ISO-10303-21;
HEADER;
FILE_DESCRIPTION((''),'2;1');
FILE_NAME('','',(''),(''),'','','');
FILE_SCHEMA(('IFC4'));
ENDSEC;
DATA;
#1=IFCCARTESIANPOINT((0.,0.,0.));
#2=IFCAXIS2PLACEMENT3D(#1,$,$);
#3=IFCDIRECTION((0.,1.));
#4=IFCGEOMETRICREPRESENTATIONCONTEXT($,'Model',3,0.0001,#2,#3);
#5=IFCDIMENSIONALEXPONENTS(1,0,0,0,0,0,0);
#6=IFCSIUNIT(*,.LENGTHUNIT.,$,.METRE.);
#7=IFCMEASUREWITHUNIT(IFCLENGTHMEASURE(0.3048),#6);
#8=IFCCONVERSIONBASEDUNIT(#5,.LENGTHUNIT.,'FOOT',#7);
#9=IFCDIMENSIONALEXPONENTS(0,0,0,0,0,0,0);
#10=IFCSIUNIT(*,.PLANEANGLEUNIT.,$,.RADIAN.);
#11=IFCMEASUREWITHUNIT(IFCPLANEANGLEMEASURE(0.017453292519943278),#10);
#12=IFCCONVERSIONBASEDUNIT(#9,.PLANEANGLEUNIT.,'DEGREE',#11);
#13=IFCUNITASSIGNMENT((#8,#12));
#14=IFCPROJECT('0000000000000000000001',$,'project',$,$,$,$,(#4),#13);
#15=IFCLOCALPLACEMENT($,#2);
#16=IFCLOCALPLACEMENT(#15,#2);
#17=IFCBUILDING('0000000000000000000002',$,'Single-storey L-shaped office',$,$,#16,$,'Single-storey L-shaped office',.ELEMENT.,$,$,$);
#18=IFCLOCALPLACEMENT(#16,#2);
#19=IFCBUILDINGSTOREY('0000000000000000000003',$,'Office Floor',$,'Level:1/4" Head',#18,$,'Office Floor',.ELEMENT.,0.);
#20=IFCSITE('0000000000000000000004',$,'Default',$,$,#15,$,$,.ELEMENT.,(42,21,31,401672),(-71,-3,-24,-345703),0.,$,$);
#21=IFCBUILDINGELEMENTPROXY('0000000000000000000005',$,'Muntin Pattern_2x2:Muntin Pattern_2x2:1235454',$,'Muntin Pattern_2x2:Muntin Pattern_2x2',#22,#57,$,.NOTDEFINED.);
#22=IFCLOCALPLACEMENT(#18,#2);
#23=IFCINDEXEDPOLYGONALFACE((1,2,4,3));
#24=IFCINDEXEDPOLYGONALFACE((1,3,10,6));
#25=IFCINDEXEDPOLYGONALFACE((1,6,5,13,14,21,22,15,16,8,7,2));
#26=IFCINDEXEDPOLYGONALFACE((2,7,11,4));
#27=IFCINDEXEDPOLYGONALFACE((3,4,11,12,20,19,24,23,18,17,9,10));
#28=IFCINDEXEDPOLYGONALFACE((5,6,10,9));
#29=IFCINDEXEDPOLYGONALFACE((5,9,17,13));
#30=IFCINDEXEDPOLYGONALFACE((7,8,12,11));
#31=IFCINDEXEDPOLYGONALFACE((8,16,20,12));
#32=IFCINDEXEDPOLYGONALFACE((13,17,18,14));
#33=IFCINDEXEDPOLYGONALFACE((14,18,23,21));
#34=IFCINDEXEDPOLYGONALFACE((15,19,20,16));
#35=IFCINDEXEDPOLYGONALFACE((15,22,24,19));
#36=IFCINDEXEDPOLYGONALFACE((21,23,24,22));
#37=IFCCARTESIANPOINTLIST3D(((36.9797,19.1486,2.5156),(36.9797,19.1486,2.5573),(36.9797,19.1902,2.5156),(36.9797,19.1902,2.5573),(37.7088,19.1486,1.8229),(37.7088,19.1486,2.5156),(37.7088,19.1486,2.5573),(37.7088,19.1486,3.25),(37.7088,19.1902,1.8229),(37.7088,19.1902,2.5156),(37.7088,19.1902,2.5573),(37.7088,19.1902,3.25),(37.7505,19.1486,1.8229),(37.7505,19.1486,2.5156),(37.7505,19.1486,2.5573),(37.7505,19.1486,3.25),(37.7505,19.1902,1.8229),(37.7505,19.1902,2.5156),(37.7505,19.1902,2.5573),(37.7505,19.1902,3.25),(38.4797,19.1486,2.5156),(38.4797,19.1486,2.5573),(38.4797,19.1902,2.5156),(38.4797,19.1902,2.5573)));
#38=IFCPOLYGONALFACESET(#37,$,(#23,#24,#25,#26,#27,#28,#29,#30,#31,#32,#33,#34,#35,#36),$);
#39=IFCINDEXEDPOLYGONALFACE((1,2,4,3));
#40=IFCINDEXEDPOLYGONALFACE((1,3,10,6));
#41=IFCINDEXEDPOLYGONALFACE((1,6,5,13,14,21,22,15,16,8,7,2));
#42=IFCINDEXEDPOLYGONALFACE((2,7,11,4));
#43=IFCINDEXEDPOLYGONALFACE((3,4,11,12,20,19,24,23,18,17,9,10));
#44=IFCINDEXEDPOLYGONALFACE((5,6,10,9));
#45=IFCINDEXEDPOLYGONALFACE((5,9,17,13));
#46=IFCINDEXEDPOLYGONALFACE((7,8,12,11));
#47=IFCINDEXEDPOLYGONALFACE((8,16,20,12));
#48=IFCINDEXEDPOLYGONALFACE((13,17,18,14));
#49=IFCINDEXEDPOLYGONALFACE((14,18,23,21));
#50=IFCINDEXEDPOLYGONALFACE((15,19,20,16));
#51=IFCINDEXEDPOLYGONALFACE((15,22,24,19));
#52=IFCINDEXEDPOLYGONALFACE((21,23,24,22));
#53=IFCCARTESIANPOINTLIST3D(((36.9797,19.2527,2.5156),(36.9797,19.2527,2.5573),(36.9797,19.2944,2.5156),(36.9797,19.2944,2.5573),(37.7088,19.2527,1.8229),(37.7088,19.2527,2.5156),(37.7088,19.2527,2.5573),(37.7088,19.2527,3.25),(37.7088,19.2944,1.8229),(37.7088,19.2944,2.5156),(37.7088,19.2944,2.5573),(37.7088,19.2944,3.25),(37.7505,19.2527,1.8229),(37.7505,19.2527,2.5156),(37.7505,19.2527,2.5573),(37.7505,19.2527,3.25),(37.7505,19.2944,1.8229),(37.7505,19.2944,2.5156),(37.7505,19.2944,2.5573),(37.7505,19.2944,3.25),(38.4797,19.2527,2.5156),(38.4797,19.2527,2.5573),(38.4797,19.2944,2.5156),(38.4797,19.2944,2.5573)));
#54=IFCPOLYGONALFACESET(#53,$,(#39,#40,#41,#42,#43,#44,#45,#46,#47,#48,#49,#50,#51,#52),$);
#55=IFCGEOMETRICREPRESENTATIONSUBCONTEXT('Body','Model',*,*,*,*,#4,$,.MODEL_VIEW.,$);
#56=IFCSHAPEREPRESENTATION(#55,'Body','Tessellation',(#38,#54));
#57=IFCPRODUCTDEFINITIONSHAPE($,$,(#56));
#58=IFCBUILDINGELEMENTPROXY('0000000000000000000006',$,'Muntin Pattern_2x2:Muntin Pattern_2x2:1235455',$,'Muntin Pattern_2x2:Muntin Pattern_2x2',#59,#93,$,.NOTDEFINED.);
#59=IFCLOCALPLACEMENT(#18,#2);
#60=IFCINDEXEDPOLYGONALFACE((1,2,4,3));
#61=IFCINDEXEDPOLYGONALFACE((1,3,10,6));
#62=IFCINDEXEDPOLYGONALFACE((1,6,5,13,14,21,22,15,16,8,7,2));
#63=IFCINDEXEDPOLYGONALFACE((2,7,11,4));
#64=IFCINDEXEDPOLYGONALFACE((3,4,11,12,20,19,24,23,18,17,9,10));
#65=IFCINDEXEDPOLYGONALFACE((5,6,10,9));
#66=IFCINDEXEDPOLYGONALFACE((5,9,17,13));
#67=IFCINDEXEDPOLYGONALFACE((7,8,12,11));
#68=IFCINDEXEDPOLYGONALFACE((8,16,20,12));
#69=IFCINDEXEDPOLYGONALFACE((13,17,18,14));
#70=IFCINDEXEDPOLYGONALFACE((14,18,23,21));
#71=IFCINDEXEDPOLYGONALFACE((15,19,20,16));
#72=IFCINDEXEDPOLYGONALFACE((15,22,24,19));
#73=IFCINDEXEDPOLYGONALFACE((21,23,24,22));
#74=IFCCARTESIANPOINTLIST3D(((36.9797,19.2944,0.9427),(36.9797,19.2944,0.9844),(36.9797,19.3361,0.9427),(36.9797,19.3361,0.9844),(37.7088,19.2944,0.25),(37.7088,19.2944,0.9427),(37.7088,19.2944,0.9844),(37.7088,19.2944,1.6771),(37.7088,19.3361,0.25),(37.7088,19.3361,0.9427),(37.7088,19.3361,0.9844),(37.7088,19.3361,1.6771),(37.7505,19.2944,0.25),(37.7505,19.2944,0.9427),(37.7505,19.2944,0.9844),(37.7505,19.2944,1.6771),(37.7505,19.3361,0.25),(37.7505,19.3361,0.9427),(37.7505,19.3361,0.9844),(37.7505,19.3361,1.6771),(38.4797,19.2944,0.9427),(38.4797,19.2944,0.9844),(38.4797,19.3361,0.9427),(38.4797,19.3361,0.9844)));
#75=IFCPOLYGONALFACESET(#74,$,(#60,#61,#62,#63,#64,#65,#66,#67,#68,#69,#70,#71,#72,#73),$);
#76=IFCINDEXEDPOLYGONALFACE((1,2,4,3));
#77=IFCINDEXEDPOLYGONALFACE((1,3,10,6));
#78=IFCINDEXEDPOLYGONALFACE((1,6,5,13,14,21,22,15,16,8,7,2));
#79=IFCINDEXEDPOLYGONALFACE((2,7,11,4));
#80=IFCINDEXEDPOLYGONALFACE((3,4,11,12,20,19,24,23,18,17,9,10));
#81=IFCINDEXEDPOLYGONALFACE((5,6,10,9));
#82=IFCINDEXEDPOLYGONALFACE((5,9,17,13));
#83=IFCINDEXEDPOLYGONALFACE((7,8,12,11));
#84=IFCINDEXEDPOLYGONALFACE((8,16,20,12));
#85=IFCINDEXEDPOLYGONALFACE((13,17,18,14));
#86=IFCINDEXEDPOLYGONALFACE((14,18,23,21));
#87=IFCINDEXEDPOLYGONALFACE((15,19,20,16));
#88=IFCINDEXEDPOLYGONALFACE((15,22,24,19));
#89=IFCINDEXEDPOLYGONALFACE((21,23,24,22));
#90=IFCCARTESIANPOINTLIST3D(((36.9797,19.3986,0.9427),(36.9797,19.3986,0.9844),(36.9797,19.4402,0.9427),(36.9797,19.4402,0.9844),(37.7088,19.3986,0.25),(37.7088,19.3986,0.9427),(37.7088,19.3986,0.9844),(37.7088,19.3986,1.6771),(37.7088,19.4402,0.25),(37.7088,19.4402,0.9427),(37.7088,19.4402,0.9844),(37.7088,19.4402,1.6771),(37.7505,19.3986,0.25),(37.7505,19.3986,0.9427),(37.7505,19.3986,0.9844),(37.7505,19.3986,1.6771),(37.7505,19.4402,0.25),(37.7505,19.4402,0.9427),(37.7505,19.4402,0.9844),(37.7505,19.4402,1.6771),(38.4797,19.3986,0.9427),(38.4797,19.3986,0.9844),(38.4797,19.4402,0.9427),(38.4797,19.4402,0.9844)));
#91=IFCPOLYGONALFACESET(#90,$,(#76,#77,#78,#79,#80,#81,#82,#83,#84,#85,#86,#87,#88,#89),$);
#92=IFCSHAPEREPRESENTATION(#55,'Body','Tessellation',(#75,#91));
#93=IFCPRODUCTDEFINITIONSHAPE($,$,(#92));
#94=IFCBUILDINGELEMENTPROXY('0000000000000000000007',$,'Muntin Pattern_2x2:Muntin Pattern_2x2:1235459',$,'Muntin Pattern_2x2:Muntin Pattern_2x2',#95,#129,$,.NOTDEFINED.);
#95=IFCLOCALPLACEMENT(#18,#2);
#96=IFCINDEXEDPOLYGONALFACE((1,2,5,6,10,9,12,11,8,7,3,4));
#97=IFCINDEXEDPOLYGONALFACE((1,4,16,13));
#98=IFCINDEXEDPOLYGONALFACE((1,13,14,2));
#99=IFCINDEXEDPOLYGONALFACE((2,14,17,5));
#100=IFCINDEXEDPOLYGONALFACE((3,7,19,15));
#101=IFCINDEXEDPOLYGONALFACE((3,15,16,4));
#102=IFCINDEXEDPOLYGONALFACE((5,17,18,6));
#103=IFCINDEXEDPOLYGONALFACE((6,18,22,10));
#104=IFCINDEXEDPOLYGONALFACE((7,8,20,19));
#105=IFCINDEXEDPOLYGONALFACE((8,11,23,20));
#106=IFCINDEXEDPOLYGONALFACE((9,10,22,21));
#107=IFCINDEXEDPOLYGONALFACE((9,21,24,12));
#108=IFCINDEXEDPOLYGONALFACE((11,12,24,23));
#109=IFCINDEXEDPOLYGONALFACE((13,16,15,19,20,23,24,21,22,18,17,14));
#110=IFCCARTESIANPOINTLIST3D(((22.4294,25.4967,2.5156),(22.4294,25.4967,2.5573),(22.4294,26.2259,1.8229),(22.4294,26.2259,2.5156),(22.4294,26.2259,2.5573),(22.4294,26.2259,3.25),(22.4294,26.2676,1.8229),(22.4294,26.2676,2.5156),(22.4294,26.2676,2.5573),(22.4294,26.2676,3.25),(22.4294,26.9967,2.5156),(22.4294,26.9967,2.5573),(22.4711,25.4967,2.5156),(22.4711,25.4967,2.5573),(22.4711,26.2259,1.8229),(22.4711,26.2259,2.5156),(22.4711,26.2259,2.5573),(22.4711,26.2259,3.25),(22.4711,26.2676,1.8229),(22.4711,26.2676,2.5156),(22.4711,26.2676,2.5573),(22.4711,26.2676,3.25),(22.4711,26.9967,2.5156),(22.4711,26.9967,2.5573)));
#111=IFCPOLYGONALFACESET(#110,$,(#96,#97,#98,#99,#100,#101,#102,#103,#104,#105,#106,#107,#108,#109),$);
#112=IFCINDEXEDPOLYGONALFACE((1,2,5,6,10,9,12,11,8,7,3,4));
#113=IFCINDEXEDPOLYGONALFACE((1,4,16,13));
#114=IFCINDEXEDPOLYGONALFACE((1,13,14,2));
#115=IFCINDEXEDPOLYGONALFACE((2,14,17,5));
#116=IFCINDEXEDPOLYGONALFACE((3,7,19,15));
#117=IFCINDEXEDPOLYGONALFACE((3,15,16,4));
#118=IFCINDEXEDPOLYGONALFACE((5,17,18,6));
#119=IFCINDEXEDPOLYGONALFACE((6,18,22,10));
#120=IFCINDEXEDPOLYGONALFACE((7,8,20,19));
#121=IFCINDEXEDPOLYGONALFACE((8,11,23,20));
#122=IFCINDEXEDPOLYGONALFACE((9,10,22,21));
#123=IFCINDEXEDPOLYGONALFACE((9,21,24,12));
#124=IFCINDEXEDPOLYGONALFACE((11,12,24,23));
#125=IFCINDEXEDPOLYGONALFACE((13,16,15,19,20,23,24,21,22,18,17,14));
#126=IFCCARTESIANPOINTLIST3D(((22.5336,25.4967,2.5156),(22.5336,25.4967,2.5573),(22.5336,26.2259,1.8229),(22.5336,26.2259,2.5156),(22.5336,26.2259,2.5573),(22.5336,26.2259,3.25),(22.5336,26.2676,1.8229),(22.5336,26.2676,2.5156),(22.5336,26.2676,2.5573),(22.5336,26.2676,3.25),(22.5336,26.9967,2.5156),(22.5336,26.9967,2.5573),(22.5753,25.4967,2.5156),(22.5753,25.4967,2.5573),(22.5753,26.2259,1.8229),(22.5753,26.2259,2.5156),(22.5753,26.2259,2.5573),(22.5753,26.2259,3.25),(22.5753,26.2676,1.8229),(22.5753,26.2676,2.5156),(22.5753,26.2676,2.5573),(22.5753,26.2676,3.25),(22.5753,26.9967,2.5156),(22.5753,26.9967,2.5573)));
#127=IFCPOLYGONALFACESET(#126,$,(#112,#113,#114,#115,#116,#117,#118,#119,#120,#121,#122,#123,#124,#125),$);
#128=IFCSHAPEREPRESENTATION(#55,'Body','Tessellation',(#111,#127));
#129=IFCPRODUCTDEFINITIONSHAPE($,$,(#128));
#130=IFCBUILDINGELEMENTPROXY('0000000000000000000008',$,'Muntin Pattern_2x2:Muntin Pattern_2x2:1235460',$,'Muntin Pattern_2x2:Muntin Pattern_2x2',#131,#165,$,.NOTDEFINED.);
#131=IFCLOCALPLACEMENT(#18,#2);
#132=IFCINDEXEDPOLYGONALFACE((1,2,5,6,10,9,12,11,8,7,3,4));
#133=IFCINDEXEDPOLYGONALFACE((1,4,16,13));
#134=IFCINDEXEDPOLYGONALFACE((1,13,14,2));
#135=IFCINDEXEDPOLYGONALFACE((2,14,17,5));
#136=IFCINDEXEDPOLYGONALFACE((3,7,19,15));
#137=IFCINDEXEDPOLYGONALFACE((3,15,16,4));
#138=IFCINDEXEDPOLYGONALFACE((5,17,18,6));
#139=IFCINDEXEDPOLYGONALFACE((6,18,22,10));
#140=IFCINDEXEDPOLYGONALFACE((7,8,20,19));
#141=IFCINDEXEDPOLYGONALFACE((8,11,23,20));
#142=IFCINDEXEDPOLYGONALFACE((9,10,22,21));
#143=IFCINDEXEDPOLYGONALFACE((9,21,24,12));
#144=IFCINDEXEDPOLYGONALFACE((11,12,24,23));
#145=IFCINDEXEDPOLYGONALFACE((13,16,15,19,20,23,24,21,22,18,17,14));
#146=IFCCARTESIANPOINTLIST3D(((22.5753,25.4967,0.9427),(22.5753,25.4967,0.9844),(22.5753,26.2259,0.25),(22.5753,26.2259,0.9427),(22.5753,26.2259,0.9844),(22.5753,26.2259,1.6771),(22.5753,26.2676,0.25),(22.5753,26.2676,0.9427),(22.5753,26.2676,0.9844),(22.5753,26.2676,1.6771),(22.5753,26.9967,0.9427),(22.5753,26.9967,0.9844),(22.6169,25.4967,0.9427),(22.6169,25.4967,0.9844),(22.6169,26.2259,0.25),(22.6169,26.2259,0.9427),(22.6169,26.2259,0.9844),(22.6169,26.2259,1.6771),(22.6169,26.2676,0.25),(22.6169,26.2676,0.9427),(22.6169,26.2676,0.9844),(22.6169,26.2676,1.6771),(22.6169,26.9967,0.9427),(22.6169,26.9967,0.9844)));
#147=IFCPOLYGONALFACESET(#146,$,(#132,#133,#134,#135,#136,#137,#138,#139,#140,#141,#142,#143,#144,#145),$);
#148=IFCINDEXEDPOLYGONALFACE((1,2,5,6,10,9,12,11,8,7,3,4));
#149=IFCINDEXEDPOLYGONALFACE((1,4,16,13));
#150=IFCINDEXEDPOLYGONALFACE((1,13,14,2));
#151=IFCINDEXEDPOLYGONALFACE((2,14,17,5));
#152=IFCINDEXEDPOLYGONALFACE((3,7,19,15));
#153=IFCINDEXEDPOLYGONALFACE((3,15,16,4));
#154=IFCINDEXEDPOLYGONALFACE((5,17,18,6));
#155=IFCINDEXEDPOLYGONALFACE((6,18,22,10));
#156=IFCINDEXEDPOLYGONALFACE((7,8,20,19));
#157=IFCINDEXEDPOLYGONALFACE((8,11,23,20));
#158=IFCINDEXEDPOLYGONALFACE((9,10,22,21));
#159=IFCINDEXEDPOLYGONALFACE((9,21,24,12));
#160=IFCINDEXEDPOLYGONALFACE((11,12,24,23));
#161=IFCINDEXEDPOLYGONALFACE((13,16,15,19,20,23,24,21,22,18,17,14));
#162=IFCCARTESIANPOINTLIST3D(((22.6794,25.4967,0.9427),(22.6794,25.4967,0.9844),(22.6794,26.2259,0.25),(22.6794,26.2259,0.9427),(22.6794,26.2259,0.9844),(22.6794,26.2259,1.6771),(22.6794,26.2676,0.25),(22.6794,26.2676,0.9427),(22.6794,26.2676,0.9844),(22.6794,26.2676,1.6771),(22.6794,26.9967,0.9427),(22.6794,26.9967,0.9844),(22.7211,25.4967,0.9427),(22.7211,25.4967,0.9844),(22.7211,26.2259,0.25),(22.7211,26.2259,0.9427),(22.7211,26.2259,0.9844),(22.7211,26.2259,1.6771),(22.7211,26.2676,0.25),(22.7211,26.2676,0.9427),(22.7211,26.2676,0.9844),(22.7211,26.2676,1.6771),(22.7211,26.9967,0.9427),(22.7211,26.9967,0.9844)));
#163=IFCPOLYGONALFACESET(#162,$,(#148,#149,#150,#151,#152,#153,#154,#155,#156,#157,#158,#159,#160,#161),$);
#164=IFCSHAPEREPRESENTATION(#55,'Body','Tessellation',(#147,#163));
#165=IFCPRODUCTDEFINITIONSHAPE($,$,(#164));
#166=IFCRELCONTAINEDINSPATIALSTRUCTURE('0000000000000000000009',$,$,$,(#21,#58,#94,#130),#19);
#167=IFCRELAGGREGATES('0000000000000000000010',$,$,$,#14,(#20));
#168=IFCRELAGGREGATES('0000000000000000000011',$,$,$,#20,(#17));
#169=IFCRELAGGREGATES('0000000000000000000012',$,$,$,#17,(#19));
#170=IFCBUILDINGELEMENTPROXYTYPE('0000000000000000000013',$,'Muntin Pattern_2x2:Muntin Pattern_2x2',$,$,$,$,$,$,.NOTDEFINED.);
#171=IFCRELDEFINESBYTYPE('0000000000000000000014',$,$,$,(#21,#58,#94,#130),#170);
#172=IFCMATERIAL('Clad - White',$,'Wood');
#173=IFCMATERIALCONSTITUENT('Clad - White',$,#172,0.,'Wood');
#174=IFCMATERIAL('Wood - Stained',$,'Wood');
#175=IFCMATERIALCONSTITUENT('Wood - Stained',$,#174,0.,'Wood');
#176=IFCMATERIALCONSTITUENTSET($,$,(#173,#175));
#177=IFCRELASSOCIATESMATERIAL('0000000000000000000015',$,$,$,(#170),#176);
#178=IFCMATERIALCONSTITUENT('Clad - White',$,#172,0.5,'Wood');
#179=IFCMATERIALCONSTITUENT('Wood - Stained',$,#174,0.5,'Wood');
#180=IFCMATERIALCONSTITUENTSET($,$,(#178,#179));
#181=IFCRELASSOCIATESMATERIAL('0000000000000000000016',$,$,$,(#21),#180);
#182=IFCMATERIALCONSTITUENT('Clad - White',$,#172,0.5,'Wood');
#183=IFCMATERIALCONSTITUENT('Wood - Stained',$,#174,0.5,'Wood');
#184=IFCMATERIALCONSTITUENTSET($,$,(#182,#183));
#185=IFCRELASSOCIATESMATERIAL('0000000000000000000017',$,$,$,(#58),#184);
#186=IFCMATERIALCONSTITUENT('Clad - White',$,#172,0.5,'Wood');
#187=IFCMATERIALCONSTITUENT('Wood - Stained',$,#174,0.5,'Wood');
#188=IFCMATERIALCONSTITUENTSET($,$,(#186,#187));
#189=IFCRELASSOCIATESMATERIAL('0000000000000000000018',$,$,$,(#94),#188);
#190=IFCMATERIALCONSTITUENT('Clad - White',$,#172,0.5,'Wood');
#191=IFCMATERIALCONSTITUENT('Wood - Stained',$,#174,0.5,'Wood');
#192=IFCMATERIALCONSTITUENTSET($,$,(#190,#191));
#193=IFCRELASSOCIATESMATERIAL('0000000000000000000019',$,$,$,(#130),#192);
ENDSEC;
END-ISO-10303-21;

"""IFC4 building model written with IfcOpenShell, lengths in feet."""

from ifc_helpers import new_model, entity, si_unit, converted_unit, direction, frame, origin, place, context, subcontext, project, spatial, indexed_curve, outline, extrude, source, transform, mapped, material, constituent, constituent_set, type_object, type_shapes, element, save


model = new_model("IFC4")

# Units and contexts
model_context = context("Model", 3, precision=0.0001, world=origin(), true_north=direction((0.0, 1.0)))
body_context = subcontext(model_context, "Body", "Model", "MODEL_VIEW")
ifc_project = project(units=[converted_unit("LENGTHUNIT", "FOOT", entity("IfcLengthMeasure", 0.3048), si_unit("LENGTHUNIT", "METRE"), dimensions=[1, 0, 0, 0, 0, 0, 0]), converted_unit("PLANEANGLEUNIT", "DEGREE", entity("IfcPlaneAngleMeasure", 0.017453292519943278), si_unit("PLANEANGLEUNIT", "RADIAN"), dimensions=[0, 0, 0, 0, 0, 0, 0])], contexts=[model_context])

# Site, building, storey
site_placement = place(None, origin())
site = spatial("IfcSite", under=ifc_project, at=site_placement, Name="Default", CompositionType="ELEMENT", RefLatitude=(42, 21, 31, 401672), RefLongitude=(-71, -3, -24, -345703), RefElevation=0.0)
building_placement = place(site_placement, origin())
building = spatial("IfcBuilding", under=site, at=building_placement, Name="Single-storey L-shaped office", LongName="Single-storey L-shaped office", CompositionType="ELEMENT")
storey_placement = place(building_placement, origin())
storey = spatial("IfcBuildingStorey", under=building, at=storey_placement, Name="Office Floor", ObjectType="Level:1/4\" Head", LongName="Office Floor", CompositionType="ELEMENT", Elevation=0.0)

# Shared definitions
ifc_material_1 = material(Name="Wood - Stained", Category="Wood")

# Building element proxies
ifc_material_2 = material(Name="Clad - White", Category="Wood")
ifc_constituent_1 = constituent(ifc_material_2, Name="Clad - White", Category="Wood", fraction=0.0)
ifc_constituent_2 = constituent(ifc_material_1, Name="Wood - Stained", Category="Wood", fraction=0.0)
ifc_constituent_set_1 = constituent_set(constituents=[ifc_constituent_1, ifc_constituent_2])
building_element_proxy_type_1 = type_object("IfcBuildingElementProxyType", Name="Muntin Pattern_2x2:Muntin Pattern_2x2", PredefinedType="NOTDEFINED", material=ifc_constituent_set_1)
shared_shape_1 = source(origin(), body_context, "Body", "SweptSolid", [
    extrude(outline(indexed_curve([(0.0208, -0.0208), (0.7135, -0.0208), (0.7135, 0.0208), (0.0208, 0.0208), (0.0208, 0.75), (-0.0208, 0.75), (-0.0208, 0.0208), (-0.7135, 0.0208), (-0.7135, -0.0208), (-0.0208, -0.0208), (-0.0208, -0.75), (0.0208, -0.75), (0.0208, -0.0208)], self_intersect=False)), frame((0.0, 0.0312, 0.7135), z_axis=(0.0, 1.0, 0.0), x_axis=(0.0, 0.0, 1.0)), (0.0, 0.0, 1.0), 0.0417),
    extrude(outline(indexed_curve([(0.0208, -0.0208), (0.7135, -0.0208), (0.7135, 0.0208), (0.0208, 0.0208), (0.0208, 0.75), (-0.0208, 0.75), (-0.0208, 0.0208), (-0.7135, 0.0208), (-0.7135, -0.0208), (-0.0208, -0.0208), (-0.0208, -0.75), (0.0208, -0.75), (0.0208, -0.0208)], self_intersect=False)), frame((0.0, -0.0729, 0.7135), z_axis=(0.0, 1.0, 0.0), x_axis=(0.0, 0.0, 1.0)), (0.0, 0.0, 1.0), 0.0417),
])
type_shapes(building_element_proxy_type_1, [shared_shape_1])
ifc_constituent_3 = constituent(ifc_material_2, Name="Clad - White", Category="Wood", fraction=0.5)
ifc_constituent_4 = constituent(ifc_material_1, Name="Wood - Stained", Category="Wood", fraction=0.5)
ifc_constituent_set_2 = constituent_set(constituents=[ifc_constituent_3, ifc_constituent_4])
proxy_1_placement = place(storey_placement, frame((37.7297, 19.2215, 1.8229), z_axis=(0.0, 0.0, 1.0), x_axis=(-1.0, 0.0, 0.0)))
element("IfcBuildingElementProxy", 1, at=proxy_1_placement, inside=storey, type_object=building_element_proxy_type_1, material=ifc_constituent_set_2, Name="Muntin Pattern_2x2:Muntin Pattern_2x2:1235454", ObjectType="Muntin Pattern_2x2:Muntin Pattern_2x2", PredefinedType="NOTDEFINED", context=body_context, shape_type="MappedRepresentation", body=[
    mapped(shared_shape_1, transform((0.0, 0.0, 0.0), scale=1.0)),
])
ifc_constituent_5 = constituent(ifc_material_2, Name="Clad - White", Category="Wood", fraction=0.5)
ifc_constituent_6 = constituent(ifc_material_1, Name="Wood - Stained", Category="Wood", fraction=0.5)
ifc_constituent_set_3 = constituent_set(constituents=[ifc_constituent_5, ifc_constituent_6])
proxy_2_placement = place(storey_placement, frame((37.7297, 19.3673, 0.25), z_axis=(0.0, 0.0, 1.0), x_axis=(-1.0, 0.0, 0.0)))
element("IfcBuildingElementProxy", 2, at=proxy_2_placement, inside=storey, type_object=building_element_proxy_type_1, material=ifc_constituent_set_3, Name="Muntin Pattern_2x2:Muntin Pattern_2x2:1235455", ObjectType="Muntin Pattern_2x2:Muntin Pattern_2x2", PredefinedType="NOTDEFINED", context=body_context, shape_type="MappedRepresentation", body=[
    mapped(shared_shape_1, transform((0.0, 0.0, 0.0), scale=1.0)),
])
ifc_constituent_7 = constituent(ifc_material_2, Name="Clad - White", Category="Wood", fraction=0.5)
ifc_constituent_8 = constituent(ifc_material_1, Name="Wood - Stained", Category="Wood", fraction=0.5)
ifc_constituent_set_4 = constituent_set(constituents=[ifc_constituent_7, ifc_constituent_8])
proxy_3_placement = place(storey_placement, frame((22.5023, 26.2467, 1.8229), z_axis=(0.0, 0.0, 1.0), x_axis=(0.0, 1.0, 0.0)))
element("IfcBuildingElementProxy", 3, at=proxy_3_placement, inside=storey, type_object=building_element_proxy_type_1, material=ifc_constituent_set_4, Name="Muntin Pattern_2x2:Muntin Pattern_2x2:1235459", ObjectType="Muntin Pattern_2x2:Muntin Pattern_2x2", PredefinedType="NOTDEFINED", context=body_context, shape_type="MappedRepresentation", body=[
    mapped(shared_shape_1, transform((0.0, 0.0, 0.0), scale=1.0)),
])
ifc_constituent_9 = constituent(ifc_material_2, Name="Clad - White", Category="Wood", fraction=0.5)
ifc_constituent_10 = constituent(ifc_material_1, Name="Wood - Stained", Category="Wood", fraction=0.5)
ifc_constituent_set_5 = constituent_set(constituents=[ifc_constituent_9, ifc_constituent_10])
proxy_4_placement = place(storey_placement, frame((22.6482, 26.2467, 0.25), z_axis=(0.0, 0.0, 1.0), x_axis=(0.0, 1.0, 0.0)))
element("IfcBuildingElementProxy", 4, at=proxy_4_placement, inside=storey, type_object=building_element_proxy_type_1, material=ifc_constituent_set_5, Name="Muntin Pattern_2x2:Muntin Pattern_2x2:1235460", ObjectType="Muntin Pattern_2x2:Muntin Pattern_2x2", PredefinedType="NOTDEFINED", context=body_context, shape_type="MappedRepresentation", body=[
    mapped(shared_shape_1, transform((0.0, 0.0, 0.0), scale=1.0)),
])

save(model, "model.ifc")
